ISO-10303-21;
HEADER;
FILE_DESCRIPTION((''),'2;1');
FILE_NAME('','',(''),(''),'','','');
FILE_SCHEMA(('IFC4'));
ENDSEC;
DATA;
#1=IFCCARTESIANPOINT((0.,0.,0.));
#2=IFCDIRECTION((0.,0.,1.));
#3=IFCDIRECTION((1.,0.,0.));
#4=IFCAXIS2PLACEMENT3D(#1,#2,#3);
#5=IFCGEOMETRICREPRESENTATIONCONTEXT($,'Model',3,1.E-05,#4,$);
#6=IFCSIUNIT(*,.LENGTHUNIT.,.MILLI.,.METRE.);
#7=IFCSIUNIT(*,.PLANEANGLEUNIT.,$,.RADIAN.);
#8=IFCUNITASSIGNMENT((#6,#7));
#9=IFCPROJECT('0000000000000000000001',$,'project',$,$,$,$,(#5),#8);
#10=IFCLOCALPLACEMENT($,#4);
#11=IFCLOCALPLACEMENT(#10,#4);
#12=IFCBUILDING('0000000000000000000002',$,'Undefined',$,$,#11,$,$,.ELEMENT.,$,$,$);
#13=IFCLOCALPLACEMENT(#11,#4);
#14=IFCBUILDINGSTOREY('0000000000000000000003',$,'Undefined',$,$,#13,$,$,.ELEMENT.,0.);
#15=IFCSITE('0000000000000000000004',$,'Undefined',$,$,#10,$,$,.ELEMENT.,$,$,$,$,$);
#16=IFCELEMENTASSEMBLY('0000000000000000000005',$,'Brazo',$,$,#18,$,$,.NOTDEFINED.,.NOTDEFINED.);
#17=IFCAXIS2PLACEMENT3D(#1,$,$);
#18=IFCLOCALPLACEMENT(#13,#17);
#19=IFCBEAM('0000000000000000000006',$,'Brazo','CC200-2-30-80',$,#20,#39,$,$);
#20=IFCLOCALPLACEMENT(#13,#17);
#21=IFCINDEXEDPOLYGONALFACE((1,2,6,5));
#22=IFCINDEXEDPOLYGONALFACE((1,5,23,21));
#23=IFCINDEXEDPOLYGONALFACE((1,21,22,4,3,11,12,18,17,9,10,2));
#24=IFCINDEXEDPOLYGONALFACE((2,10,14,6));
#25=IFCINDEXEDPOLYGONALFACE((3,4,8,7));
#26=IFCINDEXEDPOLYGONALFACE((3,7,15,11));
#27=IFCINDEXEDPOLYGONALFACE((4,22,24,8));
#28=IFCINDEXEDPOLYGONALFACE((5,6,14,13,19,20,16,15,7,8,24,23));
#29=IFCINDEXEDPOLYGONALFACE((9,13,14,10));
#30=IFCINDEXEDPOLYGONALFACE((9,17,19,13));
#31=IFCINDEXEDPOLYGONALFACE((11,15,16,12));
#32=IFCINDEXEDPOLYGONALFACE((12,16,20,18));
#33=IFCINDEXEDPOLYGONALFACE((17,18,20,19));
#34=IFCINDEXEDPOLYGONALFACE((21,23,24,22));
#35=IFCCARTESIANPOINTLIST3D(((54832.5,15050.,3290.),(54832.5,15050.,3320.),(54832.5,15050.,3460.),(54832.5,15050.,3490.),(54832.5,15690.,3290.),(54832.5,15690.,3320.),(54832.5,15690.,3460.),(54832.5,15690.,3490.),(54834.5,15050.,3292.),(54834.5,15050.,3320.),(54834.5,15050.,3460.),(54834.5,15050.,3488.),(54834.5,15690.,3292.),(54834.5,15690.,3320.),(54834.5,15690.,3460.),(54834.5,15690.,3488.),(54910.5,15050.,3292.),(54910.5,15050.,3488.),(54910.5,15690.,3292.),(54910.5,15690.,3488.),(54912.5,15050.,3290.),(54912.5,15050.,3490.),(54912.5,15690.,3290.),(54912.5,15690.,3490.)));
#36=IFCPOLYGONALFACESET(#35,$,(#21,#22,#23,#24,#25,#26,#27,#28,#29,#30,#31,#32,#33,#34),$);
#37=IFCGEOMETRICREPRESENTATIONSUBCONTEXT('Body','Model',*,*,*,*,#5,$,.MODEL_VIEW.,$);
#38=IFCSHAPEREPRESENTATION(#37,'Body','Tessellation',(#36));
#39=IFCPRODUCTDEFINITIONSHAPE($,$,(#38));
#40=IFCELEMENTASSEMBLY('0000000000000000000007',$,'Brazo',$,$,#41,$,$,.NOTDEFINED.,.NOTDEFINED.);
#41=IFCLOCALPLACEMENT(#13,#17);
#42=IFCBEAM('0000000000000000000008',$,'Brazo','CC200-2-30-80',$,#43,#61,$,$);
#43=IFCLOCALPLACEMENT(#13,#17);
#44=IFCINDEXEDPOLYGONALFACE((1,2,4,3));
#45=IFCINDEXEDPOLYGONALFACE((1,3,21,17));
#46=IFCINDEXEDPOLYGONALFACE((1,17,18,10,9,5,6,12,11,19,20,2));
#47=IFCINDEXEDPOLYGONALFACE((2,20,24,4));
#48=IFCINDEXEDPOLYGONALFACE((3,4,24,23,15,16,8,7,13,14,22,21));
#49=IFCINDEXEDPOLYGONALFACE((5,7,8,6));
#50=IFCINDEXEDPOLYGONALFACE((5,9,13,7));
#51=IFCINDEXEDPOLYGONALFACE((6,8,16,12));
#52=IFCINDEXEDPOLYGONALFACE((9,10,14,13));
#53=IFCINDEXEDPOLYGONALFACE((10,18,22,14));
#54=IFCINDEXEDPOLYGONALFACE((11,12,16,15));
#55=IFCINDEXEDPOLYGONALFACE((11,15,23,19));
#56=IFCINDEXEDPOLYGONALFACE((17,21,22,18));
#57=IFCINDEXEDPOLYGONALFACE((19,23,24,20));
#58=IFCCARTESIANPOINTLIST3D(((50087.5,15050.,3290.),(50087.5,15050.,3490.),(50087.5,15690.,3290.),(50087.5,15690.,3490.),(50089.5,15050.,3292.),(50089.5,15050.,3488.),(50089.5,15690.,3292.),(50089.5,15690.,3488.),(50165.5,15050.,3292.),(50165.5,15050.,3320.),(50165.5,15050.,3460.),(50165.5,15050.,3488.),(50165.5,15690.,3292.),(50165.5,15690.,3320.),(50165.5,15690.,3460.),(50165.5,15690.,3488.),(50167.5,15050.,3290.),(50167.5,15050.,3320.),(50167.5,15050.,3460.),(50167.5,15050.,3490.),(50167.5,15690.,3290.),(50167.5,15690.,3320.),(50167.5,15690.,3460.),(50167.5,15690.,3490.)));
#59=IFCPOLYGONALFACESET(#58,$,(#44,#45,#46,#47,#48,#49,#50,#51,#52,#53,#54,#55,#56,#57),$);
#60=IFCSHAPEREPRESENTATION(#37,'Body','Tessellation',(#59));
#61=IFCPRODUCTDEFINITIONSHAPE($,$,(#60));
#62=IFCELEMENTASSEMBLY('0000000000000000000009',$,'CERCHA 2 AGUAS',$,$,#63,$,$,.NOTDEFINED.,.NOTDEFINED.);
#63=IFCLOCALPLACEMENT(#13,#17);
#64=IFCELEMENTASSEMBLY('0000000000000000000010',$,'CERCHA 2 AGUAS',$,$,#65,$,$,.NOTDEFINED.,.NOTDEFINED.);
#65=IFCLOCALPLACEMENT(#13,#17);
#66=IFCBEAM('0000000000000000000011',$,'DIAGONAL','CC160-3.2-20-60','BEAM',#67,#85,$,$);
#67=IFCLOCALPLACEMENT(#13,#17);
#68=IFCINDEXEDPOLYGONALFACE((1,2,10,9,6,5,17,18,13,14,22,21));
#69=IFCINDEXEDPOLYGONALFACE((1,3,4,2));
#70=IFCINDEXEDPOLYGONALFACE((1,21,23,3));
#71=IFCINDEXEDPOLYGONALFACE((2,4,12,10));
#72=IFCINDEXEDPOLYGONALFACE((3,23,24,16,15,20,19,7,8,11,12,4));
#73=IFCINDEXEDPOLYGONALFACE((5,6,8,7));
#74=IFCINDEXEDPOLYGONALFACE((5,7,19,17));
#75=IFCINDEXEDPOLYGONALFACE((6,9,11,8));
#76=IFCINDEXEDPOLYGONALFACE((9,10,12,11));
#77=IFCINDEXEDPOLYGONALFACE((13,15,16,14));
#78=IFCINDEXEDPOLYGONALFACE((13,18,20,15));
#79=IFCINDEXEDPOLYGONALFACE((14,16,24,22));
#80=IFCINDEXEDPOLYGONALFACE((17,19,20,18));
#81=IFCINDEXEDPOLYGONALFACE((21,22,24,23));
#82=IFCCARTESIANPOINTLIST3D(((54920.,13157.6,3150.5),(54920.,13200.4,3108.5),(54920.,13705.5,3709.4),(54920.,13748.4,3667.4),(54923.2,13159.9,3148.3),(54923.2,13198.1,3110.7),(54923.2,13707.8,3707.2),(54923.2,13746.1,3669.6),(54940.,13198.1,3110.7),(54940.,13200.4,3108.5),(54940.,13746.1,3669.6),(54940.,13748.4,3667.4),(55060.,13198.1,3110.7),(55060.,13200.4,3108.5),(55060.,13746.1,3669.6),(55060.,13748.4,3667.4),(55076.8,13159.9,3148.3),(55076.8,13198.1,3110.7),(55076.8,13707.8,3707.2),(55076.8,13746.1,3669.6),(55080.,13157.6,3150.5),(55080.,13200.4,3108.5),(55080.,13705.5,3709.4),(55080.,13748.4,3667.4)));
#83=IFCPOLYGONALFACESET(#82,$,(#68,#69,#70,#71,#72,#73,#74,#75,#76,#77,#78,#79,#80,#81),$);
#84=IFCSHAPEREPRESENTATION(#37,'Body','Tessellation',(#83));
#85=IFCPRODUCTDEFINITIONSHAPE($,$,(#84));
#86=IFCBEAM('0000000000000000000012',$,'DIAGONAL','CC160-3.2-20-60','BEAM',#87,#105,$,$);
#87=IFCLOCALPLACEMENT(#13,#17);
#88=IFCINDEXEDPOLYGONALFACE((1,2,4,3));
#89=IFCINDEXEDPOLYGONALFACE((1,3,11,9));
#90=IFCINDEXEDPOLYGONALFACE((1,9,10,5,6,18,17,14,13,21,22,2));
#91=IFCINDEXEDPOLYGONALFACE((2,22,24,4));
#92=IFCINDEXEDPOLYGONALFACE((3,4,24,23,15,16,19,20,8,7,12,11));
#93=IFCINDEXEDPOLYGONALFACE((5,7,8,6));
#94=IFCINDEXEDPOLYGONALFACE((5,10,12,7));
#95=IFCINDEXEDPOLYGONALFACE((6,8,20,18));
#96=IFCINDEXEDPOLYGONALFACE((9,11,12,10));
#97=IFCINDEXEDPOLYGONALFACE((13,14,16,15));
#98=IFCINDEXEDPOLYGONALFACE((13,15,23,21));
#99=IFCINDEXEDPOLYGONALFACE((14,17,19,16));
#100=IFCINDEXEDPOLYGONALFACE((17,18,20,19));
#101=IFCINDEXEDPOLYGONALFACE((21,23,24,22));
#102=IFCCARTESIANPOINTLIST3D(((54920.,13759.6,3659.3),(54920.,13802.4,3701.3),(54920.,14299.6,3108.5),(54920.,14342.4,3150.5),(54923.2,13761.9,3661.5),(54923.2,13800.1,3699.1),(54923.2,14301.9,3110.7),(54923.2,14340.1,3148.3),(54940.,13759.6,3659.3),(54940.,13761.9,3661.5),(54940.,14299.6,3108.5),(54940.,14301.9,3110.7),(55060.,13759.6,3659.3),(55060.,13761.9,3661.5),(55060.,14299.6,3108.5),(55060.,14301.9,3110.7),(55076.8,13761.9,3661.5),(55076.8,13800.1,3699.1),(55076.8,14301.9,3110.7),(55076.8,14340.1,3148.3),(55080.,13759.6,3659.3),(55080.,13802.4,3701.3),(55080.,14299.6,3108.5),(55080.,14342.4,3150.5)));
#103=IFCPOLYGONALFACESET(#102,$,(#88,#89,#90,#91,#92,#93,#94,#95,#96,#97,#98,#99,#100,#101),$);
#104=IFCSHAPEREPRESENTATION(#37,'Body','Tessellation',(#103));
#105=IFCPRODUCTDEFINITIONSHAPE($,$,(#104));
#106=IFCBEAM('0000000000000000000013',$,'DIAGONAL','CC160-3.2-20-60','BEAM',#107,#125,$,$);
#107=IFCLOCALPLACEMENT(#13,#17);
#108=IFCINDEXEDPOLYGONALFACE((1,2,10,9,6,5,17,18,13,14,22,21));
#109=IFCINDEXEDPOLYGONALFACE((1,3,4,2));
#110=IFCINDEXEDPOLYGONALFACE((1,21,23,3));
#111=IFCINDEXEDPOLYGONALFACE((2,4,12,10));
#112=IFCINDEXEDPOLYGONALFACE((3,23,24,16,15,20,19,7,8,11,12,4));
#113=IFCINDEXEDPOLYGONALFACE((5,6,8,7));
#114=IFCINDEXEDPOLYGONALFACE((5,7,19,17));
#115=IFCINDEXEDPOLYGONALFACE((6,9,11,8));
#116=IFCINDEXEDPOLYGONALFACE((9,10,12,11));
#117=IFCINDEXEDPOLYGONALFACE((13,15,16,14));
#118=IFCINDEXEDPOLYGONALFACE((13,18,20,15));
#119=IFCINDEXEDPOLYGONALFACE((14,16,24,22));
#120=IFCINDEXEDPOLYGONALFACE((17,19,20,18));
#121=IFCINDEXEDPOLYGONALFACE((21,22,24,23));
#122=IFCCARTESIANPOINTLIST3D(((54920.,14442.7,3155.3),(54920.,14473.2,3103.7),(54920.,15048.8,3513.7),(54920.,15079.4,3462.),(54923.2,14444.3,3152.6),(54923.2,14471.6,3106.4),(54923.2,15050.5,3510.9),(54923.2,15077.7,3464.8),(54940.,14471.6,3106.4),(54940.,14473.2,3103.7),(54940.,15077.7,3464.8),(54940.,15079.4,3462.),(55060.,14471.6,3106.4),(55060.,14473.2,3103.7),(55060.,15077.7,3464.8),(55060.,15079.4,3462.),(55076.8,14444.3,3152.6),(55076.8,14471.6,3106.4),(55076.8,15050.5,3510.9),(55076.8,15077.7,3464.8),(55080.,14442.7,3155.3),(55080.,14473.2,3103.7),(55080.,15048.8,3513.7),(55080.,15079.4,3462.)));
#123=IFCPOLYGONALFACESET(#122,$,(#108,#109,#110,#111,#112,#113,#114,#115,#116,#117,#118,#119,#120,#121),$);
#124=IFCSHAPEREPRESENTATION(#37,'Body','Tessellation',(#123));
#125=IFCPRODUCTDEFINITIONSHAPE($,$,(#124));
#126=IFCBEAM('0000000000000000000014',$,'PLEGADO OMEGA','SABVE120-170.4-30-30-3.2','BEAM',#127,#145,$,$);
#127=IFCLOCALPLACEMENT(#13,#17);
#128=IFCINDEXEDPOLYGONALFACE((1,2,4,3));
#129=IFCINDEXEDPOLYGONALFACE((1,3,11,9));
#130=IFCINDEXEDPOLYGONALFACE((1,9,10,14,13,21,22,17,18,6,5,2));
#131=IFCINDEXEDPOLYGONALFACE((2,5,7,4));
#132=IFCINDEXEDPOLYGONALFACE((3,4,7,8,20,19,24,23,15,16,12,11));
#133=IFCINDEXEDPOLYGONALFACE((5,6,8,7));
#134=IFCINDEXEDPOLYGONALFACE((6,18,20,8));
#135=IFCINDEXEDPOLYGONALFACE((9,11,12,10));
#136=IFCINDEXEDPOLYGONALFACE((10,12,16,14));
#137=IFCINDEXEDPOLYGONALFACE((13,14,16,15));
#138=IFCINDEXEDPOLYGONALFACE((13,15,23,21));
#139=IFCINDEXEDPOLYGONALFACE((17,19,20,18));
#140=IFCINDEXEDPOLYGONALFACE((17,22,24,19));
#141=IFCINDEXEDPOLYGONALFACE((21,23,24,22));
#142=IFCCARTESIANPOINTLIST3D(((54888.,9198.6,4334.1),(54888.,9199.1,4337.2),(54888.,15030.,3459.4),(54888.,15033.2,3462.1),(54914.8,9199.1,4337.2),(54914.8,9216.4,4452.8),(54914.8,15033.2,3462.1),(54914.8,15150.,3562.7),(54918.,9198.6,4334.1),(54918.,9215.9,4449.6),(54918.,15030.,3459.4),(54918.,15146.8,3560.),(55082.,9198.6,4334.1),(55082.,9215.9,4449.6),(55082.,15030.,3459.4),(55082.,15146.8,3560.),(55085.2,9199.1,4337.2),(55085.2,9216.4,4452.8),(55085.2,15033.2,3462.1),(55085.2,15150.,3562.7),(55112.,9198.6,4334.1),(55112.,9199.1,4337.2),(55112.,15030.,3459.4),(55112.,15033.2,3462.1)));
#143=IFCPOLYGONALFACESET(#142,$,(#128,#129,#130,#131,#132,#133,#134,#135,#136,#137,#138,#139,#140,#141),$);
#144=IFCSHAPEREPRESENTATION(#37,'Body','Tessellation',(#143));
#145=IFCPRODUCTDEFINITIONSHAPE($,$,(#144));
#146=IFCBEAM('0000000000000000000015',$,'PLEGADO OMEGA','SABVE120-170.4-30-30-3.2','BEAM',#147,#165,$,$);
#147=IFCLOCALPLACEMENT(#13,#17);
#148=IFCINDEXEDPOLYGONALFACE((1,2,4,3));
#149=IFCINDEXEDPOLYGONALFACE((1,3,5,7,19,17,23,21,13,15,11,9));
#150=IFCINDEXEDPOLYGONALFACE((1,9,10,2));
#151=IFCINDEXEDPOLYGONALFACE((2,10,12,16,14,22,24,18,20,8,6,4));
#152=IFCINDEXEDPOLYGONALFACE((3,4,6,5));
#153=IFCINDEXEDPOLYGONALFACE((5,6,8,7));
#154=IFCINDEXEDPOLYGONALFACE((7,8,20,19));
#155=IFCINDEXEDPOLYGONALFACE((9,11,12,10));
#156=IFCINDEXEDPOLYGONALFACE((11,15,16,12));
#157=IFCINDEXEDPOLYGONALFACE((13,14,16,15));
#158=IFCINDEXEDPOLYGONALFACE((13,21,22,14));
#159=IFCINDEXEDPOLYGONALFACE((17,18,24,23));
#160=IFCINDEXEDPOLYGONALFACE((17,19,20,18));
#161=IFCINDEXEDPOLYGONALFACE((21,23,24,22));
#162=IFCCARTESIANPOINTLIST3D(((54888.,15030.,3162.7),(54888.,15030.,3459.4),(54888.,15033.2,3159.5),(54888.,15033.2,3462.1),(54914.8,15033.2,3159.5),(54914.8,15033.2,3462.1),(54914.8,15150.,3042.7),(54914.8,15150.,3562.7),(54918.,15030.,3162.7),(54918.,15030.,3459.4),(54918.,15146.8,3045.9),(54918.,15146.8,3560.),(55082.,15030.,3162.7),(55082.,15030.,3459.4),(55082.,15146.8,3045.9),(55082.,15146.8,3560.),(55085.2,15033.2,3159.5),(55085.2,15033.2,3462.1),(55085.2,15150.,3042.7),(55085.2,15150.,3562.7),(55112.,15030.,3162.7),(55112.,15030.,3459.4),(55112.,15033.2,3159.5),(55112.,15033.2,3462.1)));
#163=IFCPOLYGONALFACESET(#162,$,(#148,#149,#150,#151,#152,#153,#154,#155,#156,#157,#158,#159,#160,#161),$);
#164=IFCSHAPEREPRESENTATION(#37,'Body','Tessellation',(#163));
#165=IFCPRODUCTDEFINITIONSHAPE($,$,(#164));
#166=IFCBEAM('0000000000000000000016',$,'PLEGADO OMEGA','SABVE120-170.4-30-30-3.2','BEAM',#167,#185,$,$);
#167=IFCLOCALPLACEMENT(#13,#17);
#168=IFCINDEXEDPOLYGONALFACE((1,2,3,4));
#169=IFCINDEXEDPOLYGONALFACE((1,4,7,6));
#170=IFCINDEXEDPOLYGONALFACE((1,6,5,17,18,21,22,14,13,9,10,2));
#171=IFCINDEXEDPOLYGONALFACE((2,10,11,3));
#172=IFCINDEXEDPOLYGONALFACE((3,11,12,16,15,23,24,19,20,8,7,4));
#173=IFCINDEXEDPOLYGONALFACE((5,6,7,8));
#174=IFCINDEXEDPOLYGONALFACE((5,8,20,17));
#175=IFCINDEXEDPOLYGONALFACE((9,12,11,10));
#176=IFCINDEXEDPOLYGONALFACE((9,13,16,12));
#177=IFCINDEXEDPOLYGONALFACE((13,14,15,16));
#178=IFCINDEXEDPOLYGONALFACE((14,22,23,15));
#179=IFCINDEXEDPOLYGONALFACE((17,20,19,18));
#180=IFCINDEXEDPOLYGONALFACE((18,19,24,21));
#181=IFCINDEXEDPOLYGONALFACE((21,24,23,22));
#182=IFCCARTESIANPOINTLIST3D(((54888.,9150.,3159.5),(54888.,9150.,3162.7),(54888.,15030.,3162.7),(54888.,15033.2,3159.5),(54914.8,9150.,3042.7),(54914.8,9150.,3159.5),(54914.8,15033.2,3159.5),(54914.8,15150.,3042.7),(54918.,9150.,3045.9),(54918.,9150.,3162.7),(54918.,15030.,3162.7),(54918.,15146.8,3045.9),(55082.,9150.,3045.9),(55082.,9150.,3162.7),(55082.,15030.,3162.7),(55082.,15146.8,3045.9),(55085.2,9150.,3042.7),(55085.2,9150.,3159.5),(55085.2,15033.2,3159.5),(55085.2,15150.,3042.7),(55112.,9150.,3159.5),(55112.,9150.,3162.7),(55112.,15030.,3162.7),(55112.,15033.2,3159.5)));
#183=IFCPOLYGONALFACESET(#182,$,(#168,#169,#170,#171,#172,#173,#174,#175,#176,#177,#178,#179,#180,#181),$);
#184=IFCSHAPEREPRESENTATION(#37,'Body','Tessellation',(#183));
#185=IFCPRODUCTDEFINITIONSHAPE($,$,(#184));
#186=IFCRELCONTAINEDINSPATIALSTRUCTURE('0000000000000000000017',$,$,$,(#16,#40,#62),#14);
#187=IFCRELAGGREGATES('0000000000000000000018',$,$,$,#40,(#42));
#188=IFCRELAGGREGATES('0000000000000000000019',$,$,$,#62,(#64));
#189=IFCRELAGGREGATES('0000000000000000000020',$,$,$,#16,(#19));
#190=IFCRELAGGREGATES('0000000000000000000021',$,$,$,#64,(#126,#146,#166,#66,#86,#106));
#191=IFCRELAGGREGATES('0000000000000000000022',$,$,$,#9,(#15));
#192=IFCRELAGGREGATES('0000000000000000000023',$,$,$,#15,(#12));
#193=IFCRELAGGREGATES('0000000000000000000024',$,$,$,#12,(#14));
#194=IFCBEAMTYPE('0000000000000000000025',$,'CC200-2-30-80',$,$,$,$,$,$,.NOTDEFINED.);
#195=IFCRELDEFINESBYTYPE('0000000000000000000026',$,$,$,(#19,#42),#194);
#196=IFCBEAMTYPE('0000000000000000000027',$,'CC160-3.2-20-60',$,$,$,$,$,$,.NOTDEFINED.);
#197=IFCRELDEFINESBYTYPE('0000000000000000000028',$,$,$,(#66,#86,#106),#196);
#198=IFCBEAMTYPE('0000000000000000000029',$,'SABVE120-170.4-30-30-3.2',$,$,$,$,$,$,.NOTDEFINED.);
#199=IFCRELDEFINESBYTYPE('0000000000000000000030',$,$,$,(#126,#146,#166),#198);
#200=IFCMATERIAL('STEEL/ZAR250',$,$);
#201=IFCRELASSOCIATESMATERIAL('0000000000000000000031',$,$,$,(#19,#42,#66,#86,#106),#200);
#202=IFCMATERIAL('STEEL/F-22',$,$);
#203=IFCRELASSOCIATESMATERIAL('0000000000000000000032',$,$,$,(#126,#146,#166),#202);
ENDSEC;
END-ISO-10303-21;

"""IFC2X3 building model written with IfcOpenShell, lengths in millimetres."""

from ifc_helpers import new_model, si_unit, frame, origin_with_axes, origin_2d_with_axis, place, context, subcontext, project, spatial, polyline, c_section, outline, extrude, clip, halfspace, material, type_object, element, aggregate, save


model = new_model("IFC2X3")

# Units and contexts
model_context = context("Model", 3, precision=1e-05, world=origin_with_axes())
body_context = subcontext(model_context, "Body", "Model", "MODEL_VIEW")
ifc_project = project(units=[si_unit("LENGTHUNIT", "METRE", prefix="MILLI"), si_unit("PLANEANGLEUNIT", "RADIAN")], contexts=[model_context])

# Site, building, storey
site_placement = place(None, origin_with_axes())
site = spatial("IfcSite", under=ifc_project, at=site_placement, Name="Undefined", CompositionType="ELEMENT")
building_placement = place(site_placement, origin_with_axes())
building = spatial("IfcBuilding", under=site, at=building_placement, Name="Undefined", CompositionType="ELEMENT")
storey_placement = place(building_placement, origin_with_axes())
storey = spatial("IfcBuildingStorey", under=building, at=storey_placement, Name="Undefined", CompositionType="ELEMENT", Elevation=0.0)

# Element assemblies, beams
assembly_1_placement = place(storey_placement, origin_with_axes())
assembly_1 = element("IfcElementAssembly", 1, at=assembly_1_placement, inside=storey, Name="Brazo", AssemblyPlace="NOTDEFINED", PredefinedType="NOTDEFINED")
ifc_material_1 = material(Name="STEEL/ZAR250")
beam_type_1 = type_object("IfcBeamType", Name="CC200-2-30-80", PredefinedType="NOTDEFINED")
beam_1_placement = place(assembly_1_placement, frame((54872.5, 15690.0, 3390.0), z_axis=(0.0, 0.000005, 1.0), x_axis=(0.000004, -1.0, 0.000005)))
beam_1 = element("IfcBeam", 2, at=beam_1_placement, type_object=beam_type_1, material=ifc_material_1, Name="Brazo", Description="CC200-2-30-80", context=body_context, shape_type="SweptSolid", body=[
    extrude(c_section(Depth=200.0, Width=80.0, WallThickness=2.0, Girth=30.0, at=origin_2d_with_axis()), frame((640.0, 0.0, 0.0), z_axis=(-1.0, 0.0, 0.0), x_axis=(0.0, -1.0, 0.0)), (0.0, 0.0, 1.0), 640.0),
])
assembly_2_placement = place(storey_placement, origin_with_axes())
assembly_2 = element("IfcElementAssembly", 3, at=assembly_2_placement, inside=storey, Name="Brazo", AssemblyPlace="NOTDEFINED", PredefinedType="NOTDEFINED")
beam_2_placement = place(assembly_2_placement, frame((50127.5, 15690.0, 3390.0), z_axis=(0.0, -0.000005, -1.0), x_axis=(0.000004, -1.0, 0.000005)))
beam_2 = element("IfcBeam", 4, at=beam_2_placement, type_object=beam_type_1, material=ifc_material_1, Name="Brazo", Description="CC200-2-30-80", context=body_context, shape_type="SweptSolid", body=[
    extrude(c_section(Depth=200.0, Width=80.0, WallThickness=2.0, Girth=30.0, at=origin_2d_with_axis()), frame((640.0, 0.0, 0.0), z_axis=(-1.0, 0.0, 0.0), x_axis=(0.0, -1.0, 0.0)), (0.0, 0.0, 1.0), 640.0),
])
aggregate(assembly_2, [beam_2])

# Element assemblies, beams
assembly_3_placement = place(storey_placement, origin_with_axes())
assembly_3 = element("IfcElementAssembly", 5, at=assembly_3_placement, inside=storey, Name="CERCHA 2 AGUAS", AssemblyPlace="NOTDEFINED", PredefinedType="NOTDEFINED")
assembly_4_placement = place(assembly_3_placement, origin_with_axes())
assembly_4 = element("IfcElementAssembly", 6, at=assembly_4_placement, Name="CERCHA 2 AGUAS", AssemblyPlace="NOTDEFINED", PredefinedType="NOTDEFINED")
beam_type_2 = type_object("IfcBeamType", Name="CC160-3.2-20-60", PredefinedType="NOTDEFINED")
beam_3_placement = place(assembly_4_placement, frame((55000.0, 13726.9, 3688.4), z_axis=(-1.0, 0.0, 0.0), x_axis=(0.0, -0.700071, -0.714073)))
beam_3 = element("IfcBeam", 7, at=beam_3_placement, type_object=beam_type_2, material=ifc_material_1, Name="DIAGONAL", Description="CC160-3.2-20-60", ObjectType="BEAM", context=body_context, shape_type="SweptSolid", body=[
    extrude(c_section(Depth=160.0, Width=60.0, WallThickness=3.2, Girth=20.0, at=origin_2d_with_axis()), frame((782.7, 0.0, 0.0), z_axis=(-1.0, 0.0, 0.0), x_axis=(0.0, -1.0, 0.0)), (0.0, 0.0, 1.0), 782.7),
])
beam_4_placement = place(assembly_4_placement, frame((55000.0, 14321.0, 3129.5), z_axis=(-1.0, 0.0, 0.0), x_axis=(0.0, -0.700071, 0.714073)))
beam_4 = element("IfcBeam", 8, at=beam_4_placement, type_object=beam_type_2, material=ifc_material_1, Name="DIAGONAL", Description="CC160-3.2-20-60", ObjectType="BEAM", context=body_context, shape_type="SweptSolid", body=[
    extrude(c_section(Depth=160.0, Width=60.0, WallThickness=3.2, Girth=20.0, at=origin_2d_with_axis()), frame((771.3, 0.0, 0.0), z_axis=(-1.0, 0.0, 0.0), x_axis=(0.0, -1.0, 0.0)), (0.0, 0.0, 1.0), 771.3),
])
beam_5_placement = place(assembly_4_placement, frame((55000.0, 15064.1, 3487.8), z_axis=(-1.0, 0.0, 0.0), x_axis=(0.0, -0.860828, -0.508895)))
beam_5 = element("IfcBeam", 9, at=beam_5_placement, type_object=beam_type_2, material=ifc_material_1, Name="DIAGONAL", Description="CC160-3.2-20-60", ObjectType="BEAM", context=body_context, shape_type="SweptSolid", body=[
    extrude(c_section(Depth=160.0, Width=60.0, WallThickness=3.2, Girth=20.0, at=origin_2d_with_axis()), frame((704.1, 0.0, 0.0), z_axis=(-1.0, 0.0, 0.0), x_axis=(0.0, -1.0, 0.0)), (0.0, 0.0, 1.0), 704.1),
])
ifc_material_2 = material(Name="STEEL/F-22")
beam_type_3 = type_object("IfcBeamType", Name="SABVE120-170.4-30-30-3.2", PredefinedType="NOTDEFINED")
beam_6_placement = place(assembly_4_placement, frame((55000.0, 15141.1, 3503.4), z_axis=(0.0, -0.14834, -0.988936), x_axis=(0.0, -0.988936, 0.14834)))
beam_6 = element("IfcBeam", 10, at=beam_6_placement, type_object=beam_type_3, material=ifc_material_2, Name="PLEGADO OMEGA", Description="SABVE120-170.4-30-30-3.2", ObjectType="BEAM", context=body_context, shape_type="Clipping", body=[
    clip(extrude(outline(polyline([(82.0, 60.0), (112.0, 60.0), (112.0, 56.8), (85.2, 56.8), (85.2, -60.0), (-85.2, -60.0), (-85.2, 56.8), (-112.0, 56.8), (-112.0, 60.0), (-82.0, 60.0), (-82.0, -56.8), (82.0, -56.8), (82.0, 60.0)])), frame((6000.0, 0.0, 0.0), z_axis=(-1.0, 0.0, 0.0), x_axis=(0.0, -1.0, 0.0)), (0.0, 0.0, 1.0), 6033.8), halfspace(frame((0.0, 0.0, -60.0), z_axis=(-0.757741, 0.0, 0.652555), x_axis=(0.0, 1.0, 0.0)), False)),
])
beam_7_placement = place(assembly_4_placement, frame((55000.0, 15090.0, 3042.7), z_axis=(0.0, -1.0, -0.000003), x_axis=(0.0, -0.000003, 1.0)))
beam_7 = element("IfcBeam", 11, at=beam_7_placement, type_object=beam_type_3, material=ifc_material_2, Name="PLEGADO OMEGA", Description="SABVE120-170.4-30-30-3.2", ObjectType="BEAM", context=body_context, shape_type="Clipping", body=[
    clip(clip(extrude(outline(polyline([(82.0, 60.0), (112.0, 60.0), (112.0, 56.8), (85.2, 56.8), (85.2, -60.0), (-85.2, -60.0), (-85.2, 56.8), (-112.0, 56.8), (-112.0, 60.0), (-82.0, 60.0), (-82.0, -56.8), (82.0, -56.8), (82.0, 60.0)])), frame((581.1, 0.0, 0.0), z_axis=(-1.0, 0.0, 0.0), x_axis=(0.0, -1.0, 0.0)), (0.0, 0.0, 1.0), 633.9), halfspace(frame((520.0, 0.0, -60.0), z_axis=(-0.757741, 0.0, -0.652555), x_axis=(0.0, 1.0, 0.0)), True)), halfspace(frame((120.0, 0.0, 60.0), z_axis=(0.707106, 0.0, -0.707108), x_axis=(0.0, 1.0, 0.0)), True)),
])
beam_8_placement = place(assembly_4_placement, frame((55000.0, 15150.0, 3102.7), z_axis=(0.0, 0.0, 1.0), x_axis=(0.0, -1.0, 0.0)))
beam_8 = element("IfcBeam", 12, at=beam_8_placement, type_object=beam_type_3, material=ifc_material_2, Name="PLEGADO OMEGA", Description="SABVE120-170.4-30-30-3.2", ObjectType="BEAM", context=body_context, shape_type="Clipping", body=[
    clip(extrude(outline(polyline([(82.0, 60.0), (112.0, 60.0), (112.0, 56.8), (85.2, 56.8), (85.2, -60.0), (-85.2, -60.0), (-85.2, 56.8), (-112.0, 56.8), (-112.0, 60.0), (-82.0, 60.0), (-82.0, -56.8), (82.0, -56.8), (82.0, 60.0)])), frame((6000.0, 0.0, 0.0), z_axis=(-1.0, 0.0, 0.0), x_axis=(0.0, -1.0, 0.0)), (0.0, 0.0, 1.0), 6000.6), halfspace(frame((120.0, 0.0, 60.0), z_axis=(-0.707106, 0.0, 0.707108), x_axis=(0.0, -1.0, 0.0)), False)),
])

aggregate(assembly_3, [assembly_4])
aggregate(assembly_1, [beam_1])

aggregate(assembly_4, [beam_6, beam_7, beam_8, beam_3, beam_4, beam_5])

save(model, "model.ifc")
